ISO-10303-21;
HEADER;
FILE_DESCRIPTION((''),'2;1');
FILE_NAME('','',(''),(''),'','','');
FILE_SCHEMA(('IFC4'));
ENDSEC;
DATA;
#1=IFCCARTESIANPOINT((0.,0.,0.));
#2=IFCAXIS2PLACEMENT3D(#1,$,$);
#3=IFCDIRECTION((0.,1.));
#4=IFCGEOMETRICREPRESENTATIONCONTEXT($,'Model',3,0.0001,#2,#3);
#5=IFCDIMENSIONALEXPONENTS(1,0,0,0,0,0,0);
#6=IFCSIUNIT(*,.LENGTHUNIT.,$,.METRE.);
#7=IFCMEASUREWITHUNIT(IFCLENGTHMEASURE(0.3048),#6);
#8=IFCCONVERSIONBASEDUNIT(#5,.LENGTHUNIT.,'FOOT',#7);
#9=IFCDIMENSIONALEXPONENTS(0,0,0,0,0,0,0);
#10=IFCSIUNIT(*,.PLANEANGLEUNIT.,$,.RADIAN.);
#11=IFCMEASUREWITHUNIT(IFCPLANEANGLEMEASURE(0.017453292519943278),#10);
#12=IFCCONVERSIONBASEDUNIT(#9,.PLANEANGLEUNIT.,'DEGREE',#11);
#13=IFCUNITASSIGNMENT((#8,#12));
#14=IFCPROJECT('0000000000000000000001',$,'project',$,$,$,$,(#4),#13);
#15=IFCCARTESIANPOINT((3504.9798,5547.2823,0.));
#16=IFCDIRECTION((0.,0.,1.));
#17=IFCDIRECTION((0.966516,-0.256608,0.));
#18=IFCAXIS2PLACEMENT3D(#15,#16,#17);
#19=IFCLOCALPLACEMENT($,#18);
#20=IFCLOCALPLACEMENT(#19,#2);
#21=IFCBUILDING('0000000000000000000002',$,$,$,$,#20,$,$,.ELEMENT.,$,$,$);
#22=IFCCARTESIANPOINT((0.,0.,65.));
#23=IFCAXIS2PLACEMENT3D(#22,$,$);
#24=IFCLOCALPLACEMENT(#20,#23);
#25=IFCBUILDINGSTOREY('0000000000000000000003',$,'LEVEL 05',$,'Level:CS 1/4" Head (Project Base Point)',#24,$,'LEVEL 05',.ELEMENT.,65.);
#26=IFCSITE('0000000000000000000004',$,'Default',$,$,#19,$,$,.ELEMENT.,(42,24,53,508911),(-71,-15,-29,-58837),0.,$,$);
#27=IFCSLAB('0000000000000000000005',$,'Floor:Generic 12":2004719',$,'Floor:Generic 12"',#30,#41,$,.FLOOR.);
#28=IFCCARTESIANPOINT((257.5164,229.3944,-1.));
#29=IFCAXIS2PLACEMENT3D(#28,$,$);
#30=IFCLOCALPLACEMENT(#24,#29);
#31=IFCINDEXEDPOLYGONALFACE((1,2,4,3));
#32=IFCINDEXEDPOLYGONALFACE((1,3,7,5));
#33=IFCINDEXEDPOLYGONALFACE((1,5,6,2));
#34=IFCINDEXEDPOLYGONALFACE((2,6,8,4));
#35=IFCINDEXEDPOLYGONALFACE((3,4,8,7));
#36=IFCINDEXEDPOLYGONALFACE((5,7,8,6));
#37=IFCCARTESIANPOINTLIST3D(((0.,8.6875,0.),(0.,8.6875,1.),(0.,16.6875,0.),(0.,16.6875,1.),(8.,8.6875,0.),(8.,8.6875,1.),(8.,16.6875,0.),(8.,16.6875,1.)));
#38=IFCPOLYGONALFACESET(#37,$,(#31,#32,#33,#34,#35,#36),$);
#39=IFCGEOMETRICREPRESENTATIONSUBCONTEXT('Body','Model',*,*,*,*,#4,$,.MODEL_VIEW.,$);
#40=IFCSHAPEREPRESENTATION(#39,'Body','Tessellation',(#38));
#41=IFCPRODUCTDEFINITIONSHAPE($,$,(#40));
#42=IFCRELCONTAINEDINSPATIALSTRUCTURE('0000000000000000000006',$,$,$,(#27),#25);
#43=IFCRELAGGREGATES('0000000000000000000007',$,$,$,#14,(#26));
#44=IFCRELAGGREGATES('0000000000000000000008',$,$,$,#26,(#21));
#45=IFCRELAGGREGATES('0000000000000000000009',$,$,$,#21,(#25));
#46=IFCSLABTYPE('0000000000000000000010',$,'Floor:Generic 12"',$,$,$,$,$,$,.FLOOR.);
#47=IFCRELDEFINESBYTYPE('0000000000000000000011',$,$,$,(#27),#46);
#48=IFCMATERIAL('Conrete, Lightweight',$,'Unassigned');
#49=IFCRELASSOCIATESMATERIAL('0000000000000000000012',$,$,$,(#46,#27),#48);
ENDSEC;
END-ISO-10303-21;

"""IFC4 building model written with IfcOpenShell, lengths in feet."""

from ifc_helpers import new_model, entity, si_unit, converted_unit, direction, frame, origin, origin_2d_with_axis, place, context, subcontext, project, spatial, rectangle, extrude, material, type_object, element, save


model = new_model("IFC4")

# Units and contexts
model_context = context("Model", 3, precision=0.0001, world=origin(), true_north=direction((0.0, 1.0)))
body_context = subcontext(model_context, "Body", "Model", "MODEL_VIEW")
ifc_project = project(units=[converted_unit("LENGTHUNIT", "FOOT", entity("IfcLengthMeasure", 0.3048), si_unit("LENGTHUNIT", "METRE"), dimensions=[1, 0, 0, 0, 0, 0, 0]), converted_unit("PLANEANGLEUNIT", "DEGREE", entity("IfcPlaneAngleMeasure", 0.017453292519943278), si_unit("PLANEANGLEUNIT", "RADIAN"), dimensions=[0, 0, 0, 0, 0, 0, 0])], contexts=[model_context])

# Site, building, storey
site_placement = place(None, frame((3504.9798, 5547.2823, 0.0), z_axis=(0.0, 0.0, 1.0), x_axis=(0.966516, -0.256608, 0.0)))
site = spatial("IfcSite", under=ifc_project, at=site_placement, Name="Default", CompositionType="ELEMENT", RefLatitude=(42, 24, 53, 508911), RefLongitude=(-71, -15, -29, -58837), RefElevation=0.0)
building_placement = place(site_placement, origin())
building = spatial("IfcBuilding", under=site, at=building_placement, CompositionType="ELEMENT")
storey_placement = place(building_placement, frame((0.0, 0.0, 65.0)))
storey = spatial("IfcBuildingStorey", under=building, at=storey_placement, Name="LEVEL 05", ObjectType="Level:CS 1/4\" Head (Project Base Point)", LongName="LEVEL 05", CompositionType="ELEMENT", Elevation=65.0)

# Shared definitions
ifc_material_1 = material(Name="Conrete, Lightweight", Category="Unassigned")
slab_type = type_object("IfcSlabType", Name="Floor:Generic 12\"", PredefinedType="FLOOR", material=ifc_material_1)

# Slab
slab_1_placement = place(storey_placement, frame((257.5164, 229.3944, -1.0)))
element("IfcSlab", 1, at=slab_1_placement, inside=storey, type_object=slab_type, material=ifc_material_1, Name="Floor:Generic 12\":2004719", ObjectType="Floor:Generic 12\"", PredefinedType="FLOOR", context=body_context, shape_type="SweptSolid", body=[
    extrude(rectangle(XDim=8.0, YDim=8.0, at=origin_2d_with_axis()), frame((4.0, 12.6875, 1.0), z_axis=(0.0, 0.0, -1.0), x_axis=(-1.0, 0.0, 0.0)), (0.0, 0.0, 1.0), 1.0),
])

save(model, "model.ifc")
